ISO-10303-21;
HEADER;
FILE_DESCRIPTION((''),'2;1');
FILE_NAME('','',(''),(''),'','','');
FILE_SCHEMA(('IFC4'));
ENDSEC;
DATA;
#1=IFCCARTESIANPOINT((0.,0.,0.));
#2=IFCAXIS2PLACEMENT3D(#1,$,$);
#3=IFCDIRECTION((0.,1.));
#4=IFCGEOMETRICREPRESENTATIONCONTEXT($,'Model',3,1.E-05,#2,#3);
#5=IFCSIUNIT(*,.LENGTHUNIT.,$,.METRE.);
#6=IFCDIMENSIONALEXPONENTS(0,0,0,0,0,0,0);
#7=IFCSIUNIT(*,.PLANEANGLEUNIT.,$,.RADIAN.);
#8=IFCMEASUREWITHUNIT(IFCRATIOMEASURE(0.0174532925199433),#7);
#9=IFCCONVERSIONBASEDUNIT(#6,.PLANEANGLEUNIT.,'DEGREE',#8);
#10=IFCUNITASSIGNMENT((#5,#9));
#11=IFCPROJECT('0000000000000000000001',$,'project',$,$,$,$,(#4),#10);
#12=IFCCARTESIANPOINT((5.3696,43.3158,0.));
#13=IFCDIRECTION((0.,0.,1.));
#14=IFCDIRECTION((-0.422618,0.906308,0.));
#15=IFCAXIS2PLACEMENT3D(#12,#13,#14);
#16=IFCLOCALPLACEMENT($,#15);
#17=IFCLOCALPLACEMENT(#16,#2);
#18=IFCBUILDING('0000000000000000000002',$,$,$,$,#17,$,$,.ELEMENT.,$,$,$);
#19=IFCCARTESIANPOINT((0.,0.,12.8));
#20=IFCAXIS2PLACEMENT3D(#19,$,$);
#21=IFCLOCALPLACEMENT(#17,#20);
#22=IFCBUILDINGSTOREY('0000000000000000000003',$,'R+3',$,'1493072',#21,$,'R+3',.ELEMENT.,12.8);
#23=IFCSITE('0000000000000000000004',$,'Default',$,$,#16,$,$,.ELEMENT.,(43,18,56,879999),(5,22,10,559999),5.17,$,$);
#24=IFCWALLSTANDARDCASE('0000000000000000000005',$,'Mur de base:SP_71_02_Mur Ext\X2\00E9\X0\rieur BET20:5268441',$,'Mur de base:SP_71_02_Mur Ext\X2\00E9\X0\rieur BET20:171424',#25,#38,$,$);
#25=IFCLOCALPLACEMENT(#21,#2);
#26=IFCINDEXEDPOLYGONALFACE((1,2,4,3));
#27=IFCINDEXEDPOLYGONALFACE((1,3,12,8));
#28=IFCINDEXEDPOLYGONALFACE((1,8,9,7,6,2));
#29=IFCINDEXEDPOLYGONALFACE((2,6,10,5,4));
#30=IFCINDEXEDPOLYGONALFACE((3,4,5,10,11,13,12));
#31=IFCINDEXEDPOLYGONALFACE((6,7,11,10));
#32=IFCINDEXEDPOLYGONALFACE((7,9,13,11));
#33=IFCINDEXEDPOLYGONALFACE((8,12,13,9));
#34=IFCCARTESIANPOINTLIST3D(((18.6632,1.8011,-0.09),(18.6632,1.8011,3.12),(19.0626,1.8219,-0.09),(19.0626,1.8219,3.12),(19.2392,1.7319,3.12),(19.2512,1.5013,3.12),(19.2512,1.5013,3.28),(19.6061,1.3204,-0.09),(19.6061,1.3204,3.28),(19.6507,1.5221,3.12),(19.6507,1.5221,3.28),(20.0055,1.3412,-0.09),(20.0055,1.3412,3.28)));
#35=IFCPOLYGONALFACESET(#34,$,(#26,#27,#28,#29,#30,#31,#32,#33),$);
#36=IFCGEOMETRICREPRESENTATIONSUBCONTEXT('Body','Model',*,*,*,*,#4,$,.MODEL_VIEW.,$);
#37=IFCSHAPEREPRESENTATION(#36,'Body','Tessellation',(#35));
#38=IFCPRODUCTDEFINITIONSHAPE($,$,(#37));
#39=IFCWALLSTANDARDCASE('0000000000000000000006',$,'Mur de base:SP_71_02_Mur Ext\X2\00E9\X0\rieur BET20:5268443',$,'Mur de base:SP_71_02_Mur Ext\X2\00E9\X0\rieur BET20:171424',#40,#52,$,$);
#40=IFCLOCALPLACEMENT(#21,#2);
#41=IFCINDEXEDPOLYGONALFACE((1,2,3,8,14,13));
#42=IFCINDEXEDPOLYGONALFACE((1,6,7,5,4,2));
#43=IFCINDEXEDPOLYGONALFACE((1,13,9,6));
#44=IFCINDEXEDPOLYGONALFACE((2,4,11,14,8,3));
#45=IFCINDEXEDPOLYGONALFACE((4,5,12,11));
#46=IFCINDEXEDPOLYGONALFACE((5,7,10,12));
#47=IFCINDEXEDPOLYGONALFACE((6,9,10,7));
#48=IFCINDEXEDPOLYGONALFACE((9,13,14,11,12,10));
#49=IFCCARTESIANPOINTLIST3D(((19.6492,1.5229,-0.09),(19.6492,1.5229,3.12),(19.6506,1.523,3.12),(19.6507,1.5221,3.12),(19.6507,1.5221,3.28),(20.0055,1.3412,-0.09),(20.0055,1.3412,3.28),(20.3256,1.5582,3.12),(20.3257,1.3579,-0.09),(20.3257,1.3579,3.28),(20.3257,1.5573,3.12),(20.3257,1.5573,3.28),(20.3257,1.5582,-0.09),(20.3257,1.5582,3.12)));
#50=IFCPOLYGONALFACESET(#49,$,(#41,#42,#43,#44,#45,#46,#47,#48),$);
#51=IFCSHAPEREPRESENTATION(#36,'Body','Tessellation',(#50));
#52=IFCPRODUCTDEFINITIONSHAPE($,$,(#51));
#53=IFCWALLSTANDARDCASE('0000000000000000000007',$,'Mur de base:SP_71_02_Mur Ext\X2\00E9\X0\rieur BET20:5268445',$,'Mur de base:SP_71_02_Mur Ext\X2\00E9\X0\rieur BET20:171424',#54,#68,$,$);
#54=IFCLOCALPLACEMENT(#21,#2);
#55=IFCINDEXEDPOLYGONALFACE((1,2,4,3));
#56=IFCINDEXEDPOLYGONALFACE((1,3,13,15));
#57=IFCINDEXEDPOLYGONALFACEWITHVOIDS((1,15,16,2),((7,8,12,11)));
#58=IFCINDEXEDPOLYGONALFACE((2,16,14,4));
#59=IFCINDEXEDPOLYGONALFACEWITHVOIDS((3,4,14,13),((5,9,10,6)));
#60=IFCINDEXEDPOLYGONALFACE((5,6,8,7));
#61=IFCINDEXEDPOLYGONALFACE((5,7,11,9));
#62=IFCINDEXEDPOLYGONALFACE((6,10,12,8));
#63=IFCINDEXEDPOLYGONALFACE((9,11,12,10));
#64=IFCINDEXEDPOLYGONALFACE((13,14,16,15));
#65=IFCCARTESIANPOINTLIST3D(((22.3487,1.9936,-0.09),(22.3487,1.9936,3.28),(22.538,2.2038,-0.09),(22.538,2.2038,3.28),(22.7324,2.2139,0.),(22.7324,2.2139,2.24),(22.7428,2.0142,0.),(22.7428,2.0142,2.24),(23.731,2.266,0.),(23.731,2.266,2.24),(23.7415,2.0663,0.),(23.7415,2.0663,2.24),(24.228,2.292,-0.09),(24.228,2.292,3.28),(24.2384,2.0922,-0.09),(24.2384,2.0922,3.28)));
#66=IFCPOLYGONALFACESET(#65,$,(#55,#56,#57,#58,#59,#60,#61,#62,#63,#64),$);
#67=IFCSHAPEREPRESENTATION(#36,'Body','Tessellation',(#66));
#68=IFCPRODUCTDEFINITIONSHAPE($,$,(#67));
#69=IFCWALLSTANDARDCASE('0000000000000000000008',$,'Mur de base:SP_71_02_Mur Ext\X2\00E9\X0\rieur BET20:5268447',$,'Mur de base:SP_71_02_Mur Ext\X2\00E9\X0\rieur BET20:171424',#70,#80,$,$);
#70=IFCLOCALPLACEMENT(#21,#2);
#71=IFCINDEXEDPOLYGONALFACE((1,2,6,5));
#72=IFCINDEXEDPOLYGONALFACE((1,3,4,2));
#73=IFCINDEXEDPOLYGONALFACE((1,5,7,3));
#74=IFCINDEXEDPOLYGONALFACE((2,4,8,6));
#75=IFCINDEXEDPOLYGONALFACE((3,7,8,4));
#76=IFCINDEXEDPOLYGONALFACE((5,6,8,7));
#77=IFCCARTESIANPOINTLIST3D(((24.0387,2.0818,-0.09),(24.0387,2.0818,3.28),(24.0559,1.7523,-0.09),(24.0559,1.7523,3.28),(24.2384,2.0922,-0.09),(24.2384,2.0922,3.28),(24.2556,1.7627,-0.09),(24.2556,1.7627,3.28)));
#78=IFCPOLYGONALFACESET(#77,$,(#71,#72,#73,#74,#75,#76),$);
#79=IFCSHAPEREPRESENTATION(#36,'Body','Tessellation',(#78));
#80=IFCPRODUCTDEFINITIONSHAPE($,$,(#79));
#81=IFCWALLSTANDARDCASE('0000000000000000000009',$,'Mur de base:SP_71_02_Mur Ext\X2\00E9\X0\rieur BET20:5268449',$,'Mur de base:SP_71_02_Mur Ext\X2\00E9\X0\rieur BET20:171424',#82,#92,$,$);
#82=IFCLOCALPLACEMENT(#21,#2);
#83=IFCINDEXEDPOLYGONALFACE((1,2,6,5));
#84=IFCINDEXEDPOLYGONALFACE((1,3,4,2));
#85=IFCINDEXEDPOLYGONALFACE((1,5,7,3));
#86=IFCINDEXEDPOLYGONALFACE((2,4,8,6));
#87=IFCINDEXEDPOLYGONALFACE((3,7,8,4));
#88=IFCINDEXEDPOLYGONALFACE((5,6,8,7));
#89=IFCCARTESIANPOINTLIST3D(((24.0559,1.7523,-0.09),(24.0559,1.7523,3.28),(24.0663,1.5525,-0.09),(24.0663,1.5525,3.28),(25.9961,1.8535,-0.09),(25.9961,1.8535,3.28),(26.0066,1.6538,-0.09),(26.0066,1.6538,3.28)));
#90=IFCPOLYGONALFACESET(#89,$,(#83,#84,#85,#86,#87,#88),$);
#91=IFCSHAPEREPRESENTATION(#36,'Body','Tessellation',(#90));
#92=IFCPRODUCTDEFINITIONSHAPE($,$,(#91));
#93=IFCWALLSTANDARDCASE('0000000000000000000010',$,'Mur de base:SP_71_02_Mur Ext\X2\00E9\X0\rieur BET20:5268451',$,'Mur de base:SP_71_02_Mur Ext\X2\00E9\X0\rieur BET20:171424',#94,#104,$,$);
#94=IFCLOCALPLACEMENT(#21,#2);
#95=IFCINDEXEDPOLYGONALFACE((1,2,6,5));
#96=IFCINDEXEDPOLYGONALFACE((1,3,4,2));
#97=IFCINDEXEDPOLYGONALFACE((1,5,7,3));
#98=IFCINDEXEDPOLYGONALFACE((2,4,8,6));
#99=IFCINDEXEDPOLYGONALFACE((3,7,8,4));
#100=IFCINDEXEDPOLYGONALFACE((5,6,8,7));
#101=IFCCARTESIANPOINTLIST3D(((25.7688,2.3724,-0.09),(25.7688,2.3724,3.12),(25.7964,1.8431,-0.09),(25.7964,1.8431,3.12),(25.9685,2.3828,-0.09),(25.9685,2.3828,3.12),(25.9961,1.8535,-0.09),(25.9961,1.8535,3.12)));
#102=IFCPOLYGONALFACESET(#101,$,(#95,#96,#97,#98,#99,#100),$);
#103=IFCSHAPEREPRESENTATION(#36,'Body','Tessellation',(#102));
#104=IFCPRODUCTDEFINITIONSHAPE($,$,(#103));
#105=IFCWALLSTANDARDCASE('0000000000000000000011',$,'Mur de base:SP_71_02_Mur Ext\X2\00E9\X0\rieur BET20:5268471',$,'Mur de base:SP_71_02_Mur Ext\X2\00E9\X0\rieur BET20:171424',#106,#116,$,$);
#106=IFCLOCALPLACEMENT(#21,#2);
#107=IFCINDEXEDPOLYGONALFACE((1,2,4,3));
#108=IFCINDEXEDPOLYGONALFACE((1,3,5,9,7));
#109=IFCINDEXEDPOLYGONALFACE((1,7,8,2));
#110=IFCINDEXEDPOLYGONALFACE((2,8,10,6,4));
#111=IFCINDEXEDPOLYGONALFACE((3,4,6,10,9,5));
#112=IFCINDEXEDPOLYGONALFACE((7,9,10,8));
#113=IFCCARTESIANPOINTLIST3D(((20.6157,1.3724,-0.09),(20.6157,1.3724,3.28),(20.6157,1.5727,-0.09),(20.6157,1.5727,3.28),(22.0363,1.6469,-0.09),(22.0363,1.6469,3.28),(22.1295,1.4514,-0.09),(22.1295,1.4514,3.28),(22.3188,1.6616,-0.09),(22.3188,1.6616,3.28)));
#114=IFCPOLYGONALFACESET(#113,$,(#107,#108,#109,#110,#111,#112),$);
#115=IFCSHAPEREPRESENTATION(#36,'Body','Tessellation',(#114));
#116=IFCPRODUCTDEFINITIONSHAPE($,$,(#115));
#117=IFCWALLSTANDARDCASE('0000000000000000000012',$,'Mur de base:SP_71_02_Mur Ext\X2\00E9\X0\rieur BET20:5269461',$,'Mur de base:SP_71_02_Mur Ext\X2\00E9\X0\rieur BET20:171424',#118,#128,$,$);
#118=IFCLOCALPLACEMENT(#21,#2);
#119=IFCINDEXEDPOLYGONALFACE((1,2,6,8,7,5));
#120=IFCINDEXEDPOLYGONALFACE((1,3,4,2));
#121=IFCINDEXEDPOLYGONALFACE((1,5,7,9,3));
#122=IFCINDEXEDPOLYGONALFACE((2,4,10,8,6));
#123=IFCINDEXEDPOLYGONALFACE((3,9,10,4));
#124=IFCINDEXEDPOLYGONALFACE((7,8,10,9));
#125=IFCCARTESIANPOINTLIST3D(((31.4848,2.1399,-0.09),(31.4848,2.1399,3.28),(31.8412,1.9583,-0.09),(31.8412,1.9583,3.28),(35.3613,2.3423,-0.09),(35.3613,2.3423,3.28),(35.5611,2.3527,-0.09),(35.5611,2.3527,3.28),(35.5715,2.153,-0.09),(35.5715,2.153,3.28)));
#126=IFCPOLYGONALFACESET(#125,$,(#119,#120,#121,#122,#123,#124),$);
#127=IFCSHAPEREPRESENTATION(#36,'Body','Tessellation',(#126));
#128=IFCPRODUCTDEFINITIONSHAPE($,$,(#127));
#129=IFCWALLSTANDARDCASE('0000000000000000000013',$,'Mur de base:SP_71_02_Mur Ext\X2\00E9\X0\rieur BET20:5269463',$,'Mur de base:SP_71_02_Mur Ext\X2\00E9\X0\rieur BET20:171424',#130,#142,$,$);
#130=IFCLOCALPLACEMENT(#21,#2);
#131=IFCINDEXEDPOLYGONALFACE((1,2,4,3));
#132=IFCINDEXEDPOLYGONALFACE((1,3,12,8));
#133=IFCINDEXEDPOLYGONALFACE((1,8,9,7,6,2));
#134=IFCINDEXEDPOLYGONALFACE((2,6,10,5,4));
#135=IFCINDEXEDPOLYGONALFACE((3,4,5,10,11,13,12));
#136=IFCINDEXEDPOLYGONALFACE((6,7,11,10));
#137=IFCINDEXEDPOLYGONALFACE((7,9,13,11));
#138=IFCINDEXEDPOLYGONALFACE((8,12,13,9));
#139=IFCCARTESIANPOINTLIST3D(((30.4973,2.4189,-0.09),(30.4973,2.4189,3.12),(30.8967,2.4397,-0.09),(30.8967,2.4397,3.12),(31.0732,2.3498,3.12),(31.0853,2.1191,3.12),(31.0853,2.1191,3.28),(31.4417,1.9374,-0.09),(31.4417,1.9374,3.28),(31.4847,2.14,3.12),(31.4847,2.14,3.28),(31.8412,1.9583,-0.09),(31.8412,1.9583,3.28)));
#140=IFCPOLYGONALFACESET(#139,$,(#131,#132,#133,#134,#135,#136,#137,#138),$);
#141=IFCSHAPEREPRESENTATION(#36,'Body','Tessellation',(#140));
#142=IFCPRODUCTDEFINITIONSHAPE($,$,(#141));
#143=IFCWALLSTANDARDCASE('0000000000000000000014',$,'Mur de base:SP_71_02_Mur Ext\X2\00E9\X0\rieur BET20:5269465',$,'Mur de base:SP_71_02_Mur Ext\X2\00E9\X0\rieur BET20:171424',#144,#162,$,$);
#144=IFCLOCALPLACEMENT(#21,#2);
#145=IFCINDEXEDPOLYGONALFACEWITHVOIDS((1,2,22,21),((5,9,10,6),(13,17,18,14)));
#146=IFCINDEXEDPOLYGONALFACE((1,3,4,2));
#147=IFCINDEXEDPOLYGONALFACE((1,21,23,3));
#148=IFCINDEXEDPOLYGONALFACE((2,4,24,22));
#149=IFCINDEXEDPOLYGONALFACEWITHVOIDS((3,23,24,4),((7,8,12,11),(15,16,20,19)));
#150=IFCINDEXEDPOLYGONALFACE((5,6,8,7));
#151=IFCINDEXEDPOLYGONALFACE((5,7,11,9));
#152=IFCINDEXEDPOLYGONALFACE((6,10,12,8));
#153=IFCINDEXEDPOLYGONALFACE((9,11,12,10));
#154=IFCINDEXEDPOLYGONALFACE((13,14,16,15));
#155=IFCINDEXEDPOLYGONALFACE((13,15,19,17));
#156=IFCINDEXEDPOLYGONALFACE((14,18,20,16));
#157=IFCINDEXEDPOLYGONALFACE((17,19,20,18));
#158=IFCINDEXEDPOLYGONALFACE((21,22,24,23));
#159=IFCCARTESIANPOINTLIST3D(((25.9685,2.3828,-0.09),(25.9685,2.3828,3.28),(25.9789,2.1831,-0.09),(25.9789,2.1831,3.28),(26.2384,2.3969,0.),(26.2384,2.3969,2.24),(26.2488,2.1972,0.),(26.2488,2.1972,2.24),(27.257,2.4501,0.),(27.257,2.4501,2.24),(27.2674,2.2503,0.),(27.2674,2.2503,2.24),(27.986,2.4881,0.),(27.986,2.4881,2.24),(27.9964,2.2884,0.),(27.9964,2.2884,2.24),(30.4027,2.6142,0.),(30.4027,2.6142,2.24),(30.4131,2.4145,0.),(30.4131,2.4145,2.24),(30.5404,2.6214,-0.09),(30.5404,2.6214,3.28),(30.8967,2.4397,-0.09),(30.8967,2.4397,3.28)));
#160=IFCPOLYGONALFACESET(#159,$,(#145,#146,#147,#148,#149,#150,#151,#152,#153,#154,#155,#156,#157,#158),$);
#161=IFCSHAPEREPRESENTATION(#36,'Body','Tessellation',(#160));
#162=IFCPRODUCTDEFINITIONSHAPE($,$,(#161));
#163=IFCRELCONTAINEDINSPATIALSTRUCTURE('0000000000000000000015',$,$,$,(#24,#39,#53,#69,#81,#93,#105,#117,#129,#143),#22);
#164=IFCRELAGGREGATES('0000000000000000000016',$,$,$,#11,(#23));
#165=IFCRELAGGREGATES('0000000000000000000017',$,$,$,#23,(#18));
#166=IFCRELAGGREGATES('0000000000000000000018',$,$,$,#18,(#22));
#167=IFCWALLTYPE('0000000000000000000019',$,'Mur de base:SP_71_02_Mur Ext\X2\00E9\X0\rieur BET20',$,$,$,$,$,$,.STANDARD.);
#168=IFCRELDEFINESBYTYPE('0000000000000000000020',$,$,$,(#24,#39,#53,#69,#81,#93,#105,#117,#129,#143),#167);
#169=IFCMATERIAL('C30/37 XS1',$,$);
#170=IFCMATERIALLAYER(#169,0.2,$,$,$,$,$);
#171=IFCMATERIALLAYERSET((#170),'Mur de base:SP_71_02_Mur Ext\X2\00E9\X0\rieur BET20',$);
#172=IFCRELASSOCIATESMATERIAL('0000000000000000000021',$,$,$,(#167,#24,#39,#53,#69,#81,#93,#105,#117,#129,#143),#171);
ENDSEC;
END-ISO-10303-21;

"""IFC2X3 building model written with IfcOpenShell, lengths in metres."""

from ifc_helpers import new_model, entity, si_unit, converted_unit, direction, frame, frame_2d, origin, place, context, subcontext, project, spatial, polyline, rectangle, outline, extrude, clip, bounded_halfspace, material, layer, layer_set, layer_usage, type_object, element, save


model = new_model("IFC2X3")

# Units and contexts
model_context = context("Model", 3, precision=1e-05, world=origin(), true_north=direction((0.0, 1.0)))
body_context = subcontext(model_context, "Body", "Model", "MODEL_VIEW")
ifc_project = project(units=[si_unit("LENGTHUNIT", "METRE"), converted_unit("PLANEANGLEUNIT", "DEGREE", entity("IfcRatioMeasure", 0.0174532925199433), si_unit("PLANEANGLEUNIT", "RADIAN"), dimensions=[0, 0, 0, 0, 0, 0, 0])], contexts=[model_context])

# Site, building, storey
site_placement = place(None, frame((5.3696, 43.3158, 0.0), z_axis=(0.0, 0.0, 1.0), x_axis=(-0.422618, 0.906308, 0.0)))
site = spatial("IfcSite", under=ifc_project, at=site_placement, Name="Default", CompositionType="ELEMENT", RefLatitude=(43, 18, 56, 879999), RefLongitude=(5, 22, 10, 559999), RefElevation=5.17)
building_placement = place(site_placement, origin())
building = spatial("IfcBuilding", under=site, at=building_placement, CompositionType="ELEMENT")
storey_placement = place(building_placement, frame((0.0, 0.0, 12.8)))
storey = spatial("IfcBuildingStorey", under=building, at=storey_placement, Name="R+3", ObjectType="1493072", LongName="R+3", CompositionType="ELEMENT", Elevation=12.8)

# Shared definitions
ifc_material = material(Name="C30/37 XS1")

# Walls
ifc_layer_1 = layer(ifc_material, 0.2)
ifc_layer_set_1 = layer_set([ifc_layer_1], Name="Mur de base:SP_71_02_Mur Extérieur BET20")
ifc_layer_usage_1 = layer_usage(ifc_layer_set_1, "AXIS2", "NEGATIVE", 0.1)
wall_type_1 = type_object("IfcWallType", Name="Mur de base:SP_71_02_Mur Extérieur BET20", PredefinedType="STANDARD", material=ifc_layer_set_1)
wall_1_placement = place(storey_placement, frame((19.9601, 1.2521, -0.09), z_axis=(0.0, 0.0, 1.0), x_axis=(-0.890908, 0.454183, 0.0)))
element("IfcWallStandardCase", 1, at=wall_1_placement, inside=storey, type_object=wall_type_1, material=ifc_layer_usage_1, Name="Mur de base:SP_71_02_Mur Extérieur BET20:5268441", ObjectType="Mur de base:SP_71_02_Mur Extérieur BET20:171424", context=body_context, shape_type="Clipping", body=[
    clip(clip(extrude(outline(polyline([(1.0584, -0.1), (1.4048, 0.1), (0.3464, 0.1), (0.0, -0.1), (0.4, -0.1), (1.0584, -0.1)])), origin(), (0.0, 0.0, 1.0), 3.37), bounded_halfspace(frame((0.7447, 0.1, 3.21), z_axis=(0.0, 0.0, -1.0), x_axis=(-0.890908, -0.454183, 0.0)), True, frame((0.7447, 0.1, 3.21), z_axis=(0.0, 0.0, -1.0), x_axis=(-0.890908, -0.454183, 0.0)), polyline([(0.0, 0.0), (-0.5881, -0.2998), (-0.1886, -0.3206), (0.398, -0.0216), (0.3995, -0.0208), (0.0, 0.0)]))), bounded_halfspace(frame((0.3983, -0.1, 3.21), z_axis=(-0.5, 0.866025, 0.0), x_axis=(0.0, 0.0, 1.0)), True, frame((0.3983, -0.1, 3.21), z_axis=(-0.5, 0.866025, 0.0), x_axis=(0.0, 0.0, 1.0)), polyline([(0.0, 0.0), (0.16, 0.0), (0.16, 0.4), (0.1453, 0.4), (0.0, 0.4), (0.0, 0.0)]))),
])
ifc_layer_usage_2 = layer_usage(ifc_layer_set_1, "AXIS2", "NEGATIVE", 0.1)
wall_2_placement = place(storey_placement, frame((19.6544, 1.423, -0.09), z_axis=(0.0, 0.0, 1.0), x_axis=(0.998641, 0.05212, 0.0)))
element("IfcWallStandardCase", 2, at=wall_2_placement, inside=storey, type_object=wall_type_1, material=ifc_layer_usage_2, Name="Mur de base:SP_71_02_Mur Extérieur BET20:5268443", ObjectType="Mur de base:SP_71_02_Mur Extérieur BET20:171424", context=body_context, shape_type="Clipping", body=[
    clip(clip(extrude(outline(polyline([(0.667, -0.1), (0.6774, 0.1), (0.4271, 0.1), (0.0, 0.1), (0.3464, -0.1), (0.667, -0.1)])), origin(), (0.0, 0.0, 1.0), 3.37), bounded_halfspace(frame((0.0015, 0.0992, 3.21), z_axis=(0.0, 0.0, -1.0), x_axis=(0.998641, -0.05212, 0.0)), True, frame((0.0015, 0.0992, 3.21), z_axis=(0.0, 0.0, -1.0), x_axis=(0.998641, -0.05212, 0.0)), polyline([(0.0, 0.0), (-0.0015, -0.0008), (0.675, -0.0361), (0.675, -0.0352), (0.0, 0.0)]))), bounded_halfspace(frame((0.6774, 0.0992, 3.21), z_axis=(0.0, -1.0, 0.0), x_axis=(0.0, 0.0, 1.0)), True, frame((0.6774, 0.0992, 3.21), z_axis=(0.0, -1.0, 0.0), x_axis=(0.0, 0.0, 1.0)), polyline([(0.0, 0.0), (0.16, 0.0), (0.16, 0.6759), (0.0, 0.6759), (0.0, 0.0)]))),
])

# Wall, opening
ifc_layer_usage_3 = layer_usage(ifc_layer_set_1, "AXIS2", "NEGATIVE", 0.1)
wall_3_placement = place(storey_placement, frame((22.3435, 2.0935, -0.09), z_axis=(0.0, 0.0, 1.0), x_axis=(0.998641, 0.05212, 0.0)))
wall_3 = element("IfcWallStandardCase", 3, at=wall_3_placement, inside=storey, type_object=wall_type_1, material=ifc_layer_usage_3, Name="Mur de base:SP_71_02_Mur Extérieur BET20:5268445", ObjectType="Mur de base:SP_71_02_Mur Extérieur BET20:171424", context=body_context, shape_type="SweptSolid", body=[
    extrude(outline(polyline([(1.8923, -0.1), (1.8923, 0.1), (0.2, 0.1), (0.0, -0.1), (0.2828, -0.1), (1.6923, -0.1), (1.8923, -0.1)])), origin(), (0.0, 0.0, 1.0), 3.37),
])
opening_1_placement = place(wall_3_placement, origin())
element("IfcOpeningElement", 4, at=opening_1_placement, cuts=wall_3, ObjectType="Opening", context=body_context, shape_type="SweptSolid", body=[
    extrude(rectangle(XDim=2.24, YDim=1.0, at=frame_2d((0.0, 0.0), x_axis=(1.0, 0.0))), frame((0.8947, -1.424, 1.21), z_axis=(0.0, 1.0, 0.0), x_axis=(0.0, 0.0, -1.0)), (0.0, 0.0, 1.0), 3.048),
])

# Walls
ifc_layer_usage_4 = layer_usage(ifc_layer_set_1, "AXIS2", "NEGATIVE", 0.1)
wall_4_placement = place(storey_placement, frame((24.1385, 2.087, -0.09), z_axis=(0.0, 0.0, 1.0), x_axis=(0.05212, -0.998641, 0.0)))
element("IfcWallStandardCase", 5, at=wall_4_placement, inside=storey, type_object=wall_type_1, material=ifc_layer_usage_4, Name="Mur de base:SP_71_02_Mur Extérieur BET20:5268447", ObjectType="Mur de base:SP_71_02_Mur Extérieur BET20:171424", context=body_context, shape_type="SweptSolid", body=[
    extrude(rectangle(XDim=0.33, YDim=0.2, at=frame_2d((0.165, 0.0), x_axis=(-1.0, 0.0))), origin(), (0.0, 0.0, 1.0), 3.37),
])
ifc_layer_usage_5 = layer_usage(ifc_layer_set_1, "AXIS2", "NEGATIVE", 0.1)
wall_5_placement = place(storey_placement, frame((24.0611, 1.6524, -0.09), z_axis=(0.0, 0.0, 1.0), x_axis=(0.998641, 0.05212, 0.0)))
element("IfcWallStandardCase", 6, at=wall_5_placement, inside=storey, type_object=wall_type_1, material=ifc_layer_usage_5, Name="Mur de base:SP_71_02_Mur Extérieur BET20:5268449", ObjectType="Mur de base:SP_71_02_Mur Extérieur BET20:171424", context=body_context, shape_type="SweptSolid", body=[
    extrude(rectangle(XDim=1.9429, YDim=0.2, at=frame_2d((0.9714, 0.0), x_axis=(-1.0, 0.0))), origin(), (0.0, 0.0, 1.0), 3.37),
])
ifc_layer_usage_6 = layer_usage(ifc_layer_set_1, "AXIS2", "NEGATIVE", 0.1)
wall_6_placement = place(storey_placement, frame((25.8686, 2.3776, -0.09), z_axis=(0.0, 0.0, 1.0), x_axis=(0.05212, -0.998641, 0.0)))
element("IfcWallStandardCase", 7, at=wall_6_placement, inside=storey, type_object=wall_type_1, material=ifc_layer_usage_6, Name="Mur de base:SP_71_02_Mur Extérieur BET20:5268451", ObjectType="Mur de base:SP_71_02_Mur Extérieur BET20:171424", context=body_context, shape_type="Clipping", body=[
    clip(extrude(rectangle(XDim=0.53, YDim=0.2, at=frame_2d((0.265, 0.0), x_axis=(-1.0, 0.0))), origin(), (0.0, 0.0, 1.0), 3.21), bounded_halfspace(frame((0.0, -0.1, 3.21), z_axis=(0.0, 0.0, -1.0), x_axis=(0.998641, -0.05212, 0.0)), True, frame((0.0, -0.1, 3.21), z_axis=(0.0, 0.0, -1.0), x_axis=(0.998641, -0.05212, 0.0)), polyline([(0.0, 0.0), (-0.0104, -0.1997), (0.5189, -0.2274), (0.5293, -0.0276), (0.0, 0.0)]))),
])
ifc_layer_usage_7 = layer_usage(ifc_layer_set_1, "AXIS2", "NEGATIVE", 0.1)
wall_7_placement = place(storey_placement, frame((20.6104, 1.4723, -0.09), z_axis=(0.0, 0.0, 1.0), x_axis=(0.998641, 0.05212, 0.0)))
element("IfcWallStandardCase", 8, at=wall_7_placement, inside=storey, type_object=wall_type_1, material=ifc_layer_usage_7, Name="Mur de base:SP_71_02_Mur Extérieur BET20:5268471", ObjectType="Mur de base:SP_71_02_Mur Extérieur BET20:171424", context=body_context, shape_type="SweptSolid", body=[
    extrude(outline(polyline([(1.5159, -0.1), (1.7159, 0.1), (1.433, 0.1), (0.0104, 0.1), (0.0, -0.1), (1.5159, -0.1)])), origin(), (0.0, 0.0, 1.0), 3.37),
])
ifc_layer_usage_8 = layer_usage(ifc_layer_set_1, "AXIS2", "NEGATIVE", 0.1)
wall_8_placement = place(storey_placement, frame((31.49, 2.0401, -0.09), z_axis=(0.0, 0.0, 1.0), x_axis=(0.998641, 0.05212, 0.0)))
element("IfcWallStandardCase", 9, at=wall_8_placement, inside=storey, type_object=wall_type_1, material=ifc_layer_usage_8, Name="Mur de base:SP_71_02_Mur Extérieur BET20:5269461", ObjectType="Mur de base:SP_71_02_Mur Extérieur BET20:171424", context=body_context, shape_type="SweptSolid", body=[
    extrude(outline(polyline([(4.0818, -0.1), (4.0818, 0.1), (3.8818, 0.1), (0.0, 0.1), (0.3464, -0.1), (4.0818, -0.1)])), origin(), (0.0, 0.0, 1.0), 3.37),
])
ifc_layer_usage_9 = layer_usage(ifc_layer_set_1, "AXIS2", "NEGATIVE", 0.1)
wall_9_placement = place(storey_placement, frame((30.5427, 2.508, -0.09), z_axis=(0.0, 0.0, 1.0), x_axis=(0.890908, -0.454183, 0.0)))
element("IfcWallStandardCase", 10, at=wall_9_placement, inside=storey, type_object=wall_type_1, material=ifc_layer_usage_9, Name="Mur de base:SP_71_02_Mur Extérieur BET20:5269463", ObjectType="Mur de base:SP_71_02_Mur Extérieur BET20:171424", context=body_context, shape_type="Clipping", body=[
    clip(clip(extrude(outline(polyline([(1.0601, -0.1), (1.4065, 0.1), (1.0065, 0.1), (0.3464, 0.1), (0.0, -0.1), (1.0601, -0.1)])), origin(), (0.0, 0.0, 1.0), 3.37), bounded_halfspace(frame((0.66, -0.1, 3.21), z_axis=(0.0, 0.0, -1.0), x_axis=(0.454183, -0.890908, 0.0)), True, frame((0.66, -0.1, 3.21), z_axis=(0.0, 0.0, -1.0), x_axis=(0.454183, -0.890908, 0.0)), polyline([(0.0, 0.0), (-0.2998, 0.588), (-0.3206, 0.1885), (-0.0208, -0.3995), (-0.0057, -0.1091), (0.0, 0.0)]))), bounded_halfspace(frame((1.0064, 0.1, 3.21), z_axis=(0.5, -0.866025, 0.0), x_axis=(0.0, 0.0, 1.0)), True, frame((1.0064, 0.1, 3.21), z_axis=(0.5, -0.866025, 0.0), x_axis=(0.0, 0.0, 1.0)), polyline([(0.0, 0.0), (0.16, 0.0), (0.16, 0.4), (0.0, 0.4), (0.0, 0.2908), (0.0, 0.0)]))),
])

# Wall, openings
ifc_layer_usage_10 = layer_usage(ifc_layer_set_1, "AXIS2", "NEGATIVE", 0.1)
wall_10_placement = place(storey_placement, frame((25.9737, 2.2829, -0.09), z_axis=(0.0, 0.0, 1.0), x_axis=(0.998641, 0.05212, 0.0)))
wall_10 = element("IfcWallStandardCase", 11, at=wall_10_placement, inside=storey, type_object=wall_type_1, material=ifc_layer_usage_10, Name="Mur de base:SP_71_02_Mur Extérieur BET20:5269465", ObjectType="Mur de base:SP_71_02_Mur Extérieur BET20:171424", context=body_context, shape_type="SweptSolid", body=[
    extrude(outline(polyline([(4.9245, -0.1), (4.5781, 0.1), (0.0, 0.1), (0.0, -0.1), (4.5245, -0.1), (4.9245, -0.1)])), origin(), (0.0, 0.0, 1.0), 3.37),
])
opening_2_placement = place(wall_10_placement, origin())
element("IfcOpeningElement", 12, at=opening_2_placement, cuts=wall_10, ObjectType="Opening", context=body_context, shape_type="SweptSolid", body=[
    extrude(rectangle(XDim=2.24, YDim=2.42, at=frame_2d((0.0, 0.0), x_axis=(1.0, 0.0))), frame((3.2302, -1.424, 1.21), z_axis=(0.0, 1.0, 0.0), x_axis=(0.0, 0.0, -1.0)), (0.0, 0.0, 1.0), 3.048),
])
opening_3_placement = place(wall_10_placement, origin())
element("IfcOpeningElement", 13, at=opening_3_placement, cuts=wall_10, ObjectType="Opening", context=body_context, shape_type="SweptSolid", body=[
    extrude(rectangle(XDim=2.24, YDim=1.02, at=frame_2d((0.0, 0.0), x_axis=(1.0, 0.0))), frame((0.7802, -1.424, 1.21), z_axis=(0.0, 1.0, 0.0), x_axis=(0.0, 0.0, -1.0)), (0.0, 0.0, 1.0), 3.048),
])

save(model, "model.ifc")
